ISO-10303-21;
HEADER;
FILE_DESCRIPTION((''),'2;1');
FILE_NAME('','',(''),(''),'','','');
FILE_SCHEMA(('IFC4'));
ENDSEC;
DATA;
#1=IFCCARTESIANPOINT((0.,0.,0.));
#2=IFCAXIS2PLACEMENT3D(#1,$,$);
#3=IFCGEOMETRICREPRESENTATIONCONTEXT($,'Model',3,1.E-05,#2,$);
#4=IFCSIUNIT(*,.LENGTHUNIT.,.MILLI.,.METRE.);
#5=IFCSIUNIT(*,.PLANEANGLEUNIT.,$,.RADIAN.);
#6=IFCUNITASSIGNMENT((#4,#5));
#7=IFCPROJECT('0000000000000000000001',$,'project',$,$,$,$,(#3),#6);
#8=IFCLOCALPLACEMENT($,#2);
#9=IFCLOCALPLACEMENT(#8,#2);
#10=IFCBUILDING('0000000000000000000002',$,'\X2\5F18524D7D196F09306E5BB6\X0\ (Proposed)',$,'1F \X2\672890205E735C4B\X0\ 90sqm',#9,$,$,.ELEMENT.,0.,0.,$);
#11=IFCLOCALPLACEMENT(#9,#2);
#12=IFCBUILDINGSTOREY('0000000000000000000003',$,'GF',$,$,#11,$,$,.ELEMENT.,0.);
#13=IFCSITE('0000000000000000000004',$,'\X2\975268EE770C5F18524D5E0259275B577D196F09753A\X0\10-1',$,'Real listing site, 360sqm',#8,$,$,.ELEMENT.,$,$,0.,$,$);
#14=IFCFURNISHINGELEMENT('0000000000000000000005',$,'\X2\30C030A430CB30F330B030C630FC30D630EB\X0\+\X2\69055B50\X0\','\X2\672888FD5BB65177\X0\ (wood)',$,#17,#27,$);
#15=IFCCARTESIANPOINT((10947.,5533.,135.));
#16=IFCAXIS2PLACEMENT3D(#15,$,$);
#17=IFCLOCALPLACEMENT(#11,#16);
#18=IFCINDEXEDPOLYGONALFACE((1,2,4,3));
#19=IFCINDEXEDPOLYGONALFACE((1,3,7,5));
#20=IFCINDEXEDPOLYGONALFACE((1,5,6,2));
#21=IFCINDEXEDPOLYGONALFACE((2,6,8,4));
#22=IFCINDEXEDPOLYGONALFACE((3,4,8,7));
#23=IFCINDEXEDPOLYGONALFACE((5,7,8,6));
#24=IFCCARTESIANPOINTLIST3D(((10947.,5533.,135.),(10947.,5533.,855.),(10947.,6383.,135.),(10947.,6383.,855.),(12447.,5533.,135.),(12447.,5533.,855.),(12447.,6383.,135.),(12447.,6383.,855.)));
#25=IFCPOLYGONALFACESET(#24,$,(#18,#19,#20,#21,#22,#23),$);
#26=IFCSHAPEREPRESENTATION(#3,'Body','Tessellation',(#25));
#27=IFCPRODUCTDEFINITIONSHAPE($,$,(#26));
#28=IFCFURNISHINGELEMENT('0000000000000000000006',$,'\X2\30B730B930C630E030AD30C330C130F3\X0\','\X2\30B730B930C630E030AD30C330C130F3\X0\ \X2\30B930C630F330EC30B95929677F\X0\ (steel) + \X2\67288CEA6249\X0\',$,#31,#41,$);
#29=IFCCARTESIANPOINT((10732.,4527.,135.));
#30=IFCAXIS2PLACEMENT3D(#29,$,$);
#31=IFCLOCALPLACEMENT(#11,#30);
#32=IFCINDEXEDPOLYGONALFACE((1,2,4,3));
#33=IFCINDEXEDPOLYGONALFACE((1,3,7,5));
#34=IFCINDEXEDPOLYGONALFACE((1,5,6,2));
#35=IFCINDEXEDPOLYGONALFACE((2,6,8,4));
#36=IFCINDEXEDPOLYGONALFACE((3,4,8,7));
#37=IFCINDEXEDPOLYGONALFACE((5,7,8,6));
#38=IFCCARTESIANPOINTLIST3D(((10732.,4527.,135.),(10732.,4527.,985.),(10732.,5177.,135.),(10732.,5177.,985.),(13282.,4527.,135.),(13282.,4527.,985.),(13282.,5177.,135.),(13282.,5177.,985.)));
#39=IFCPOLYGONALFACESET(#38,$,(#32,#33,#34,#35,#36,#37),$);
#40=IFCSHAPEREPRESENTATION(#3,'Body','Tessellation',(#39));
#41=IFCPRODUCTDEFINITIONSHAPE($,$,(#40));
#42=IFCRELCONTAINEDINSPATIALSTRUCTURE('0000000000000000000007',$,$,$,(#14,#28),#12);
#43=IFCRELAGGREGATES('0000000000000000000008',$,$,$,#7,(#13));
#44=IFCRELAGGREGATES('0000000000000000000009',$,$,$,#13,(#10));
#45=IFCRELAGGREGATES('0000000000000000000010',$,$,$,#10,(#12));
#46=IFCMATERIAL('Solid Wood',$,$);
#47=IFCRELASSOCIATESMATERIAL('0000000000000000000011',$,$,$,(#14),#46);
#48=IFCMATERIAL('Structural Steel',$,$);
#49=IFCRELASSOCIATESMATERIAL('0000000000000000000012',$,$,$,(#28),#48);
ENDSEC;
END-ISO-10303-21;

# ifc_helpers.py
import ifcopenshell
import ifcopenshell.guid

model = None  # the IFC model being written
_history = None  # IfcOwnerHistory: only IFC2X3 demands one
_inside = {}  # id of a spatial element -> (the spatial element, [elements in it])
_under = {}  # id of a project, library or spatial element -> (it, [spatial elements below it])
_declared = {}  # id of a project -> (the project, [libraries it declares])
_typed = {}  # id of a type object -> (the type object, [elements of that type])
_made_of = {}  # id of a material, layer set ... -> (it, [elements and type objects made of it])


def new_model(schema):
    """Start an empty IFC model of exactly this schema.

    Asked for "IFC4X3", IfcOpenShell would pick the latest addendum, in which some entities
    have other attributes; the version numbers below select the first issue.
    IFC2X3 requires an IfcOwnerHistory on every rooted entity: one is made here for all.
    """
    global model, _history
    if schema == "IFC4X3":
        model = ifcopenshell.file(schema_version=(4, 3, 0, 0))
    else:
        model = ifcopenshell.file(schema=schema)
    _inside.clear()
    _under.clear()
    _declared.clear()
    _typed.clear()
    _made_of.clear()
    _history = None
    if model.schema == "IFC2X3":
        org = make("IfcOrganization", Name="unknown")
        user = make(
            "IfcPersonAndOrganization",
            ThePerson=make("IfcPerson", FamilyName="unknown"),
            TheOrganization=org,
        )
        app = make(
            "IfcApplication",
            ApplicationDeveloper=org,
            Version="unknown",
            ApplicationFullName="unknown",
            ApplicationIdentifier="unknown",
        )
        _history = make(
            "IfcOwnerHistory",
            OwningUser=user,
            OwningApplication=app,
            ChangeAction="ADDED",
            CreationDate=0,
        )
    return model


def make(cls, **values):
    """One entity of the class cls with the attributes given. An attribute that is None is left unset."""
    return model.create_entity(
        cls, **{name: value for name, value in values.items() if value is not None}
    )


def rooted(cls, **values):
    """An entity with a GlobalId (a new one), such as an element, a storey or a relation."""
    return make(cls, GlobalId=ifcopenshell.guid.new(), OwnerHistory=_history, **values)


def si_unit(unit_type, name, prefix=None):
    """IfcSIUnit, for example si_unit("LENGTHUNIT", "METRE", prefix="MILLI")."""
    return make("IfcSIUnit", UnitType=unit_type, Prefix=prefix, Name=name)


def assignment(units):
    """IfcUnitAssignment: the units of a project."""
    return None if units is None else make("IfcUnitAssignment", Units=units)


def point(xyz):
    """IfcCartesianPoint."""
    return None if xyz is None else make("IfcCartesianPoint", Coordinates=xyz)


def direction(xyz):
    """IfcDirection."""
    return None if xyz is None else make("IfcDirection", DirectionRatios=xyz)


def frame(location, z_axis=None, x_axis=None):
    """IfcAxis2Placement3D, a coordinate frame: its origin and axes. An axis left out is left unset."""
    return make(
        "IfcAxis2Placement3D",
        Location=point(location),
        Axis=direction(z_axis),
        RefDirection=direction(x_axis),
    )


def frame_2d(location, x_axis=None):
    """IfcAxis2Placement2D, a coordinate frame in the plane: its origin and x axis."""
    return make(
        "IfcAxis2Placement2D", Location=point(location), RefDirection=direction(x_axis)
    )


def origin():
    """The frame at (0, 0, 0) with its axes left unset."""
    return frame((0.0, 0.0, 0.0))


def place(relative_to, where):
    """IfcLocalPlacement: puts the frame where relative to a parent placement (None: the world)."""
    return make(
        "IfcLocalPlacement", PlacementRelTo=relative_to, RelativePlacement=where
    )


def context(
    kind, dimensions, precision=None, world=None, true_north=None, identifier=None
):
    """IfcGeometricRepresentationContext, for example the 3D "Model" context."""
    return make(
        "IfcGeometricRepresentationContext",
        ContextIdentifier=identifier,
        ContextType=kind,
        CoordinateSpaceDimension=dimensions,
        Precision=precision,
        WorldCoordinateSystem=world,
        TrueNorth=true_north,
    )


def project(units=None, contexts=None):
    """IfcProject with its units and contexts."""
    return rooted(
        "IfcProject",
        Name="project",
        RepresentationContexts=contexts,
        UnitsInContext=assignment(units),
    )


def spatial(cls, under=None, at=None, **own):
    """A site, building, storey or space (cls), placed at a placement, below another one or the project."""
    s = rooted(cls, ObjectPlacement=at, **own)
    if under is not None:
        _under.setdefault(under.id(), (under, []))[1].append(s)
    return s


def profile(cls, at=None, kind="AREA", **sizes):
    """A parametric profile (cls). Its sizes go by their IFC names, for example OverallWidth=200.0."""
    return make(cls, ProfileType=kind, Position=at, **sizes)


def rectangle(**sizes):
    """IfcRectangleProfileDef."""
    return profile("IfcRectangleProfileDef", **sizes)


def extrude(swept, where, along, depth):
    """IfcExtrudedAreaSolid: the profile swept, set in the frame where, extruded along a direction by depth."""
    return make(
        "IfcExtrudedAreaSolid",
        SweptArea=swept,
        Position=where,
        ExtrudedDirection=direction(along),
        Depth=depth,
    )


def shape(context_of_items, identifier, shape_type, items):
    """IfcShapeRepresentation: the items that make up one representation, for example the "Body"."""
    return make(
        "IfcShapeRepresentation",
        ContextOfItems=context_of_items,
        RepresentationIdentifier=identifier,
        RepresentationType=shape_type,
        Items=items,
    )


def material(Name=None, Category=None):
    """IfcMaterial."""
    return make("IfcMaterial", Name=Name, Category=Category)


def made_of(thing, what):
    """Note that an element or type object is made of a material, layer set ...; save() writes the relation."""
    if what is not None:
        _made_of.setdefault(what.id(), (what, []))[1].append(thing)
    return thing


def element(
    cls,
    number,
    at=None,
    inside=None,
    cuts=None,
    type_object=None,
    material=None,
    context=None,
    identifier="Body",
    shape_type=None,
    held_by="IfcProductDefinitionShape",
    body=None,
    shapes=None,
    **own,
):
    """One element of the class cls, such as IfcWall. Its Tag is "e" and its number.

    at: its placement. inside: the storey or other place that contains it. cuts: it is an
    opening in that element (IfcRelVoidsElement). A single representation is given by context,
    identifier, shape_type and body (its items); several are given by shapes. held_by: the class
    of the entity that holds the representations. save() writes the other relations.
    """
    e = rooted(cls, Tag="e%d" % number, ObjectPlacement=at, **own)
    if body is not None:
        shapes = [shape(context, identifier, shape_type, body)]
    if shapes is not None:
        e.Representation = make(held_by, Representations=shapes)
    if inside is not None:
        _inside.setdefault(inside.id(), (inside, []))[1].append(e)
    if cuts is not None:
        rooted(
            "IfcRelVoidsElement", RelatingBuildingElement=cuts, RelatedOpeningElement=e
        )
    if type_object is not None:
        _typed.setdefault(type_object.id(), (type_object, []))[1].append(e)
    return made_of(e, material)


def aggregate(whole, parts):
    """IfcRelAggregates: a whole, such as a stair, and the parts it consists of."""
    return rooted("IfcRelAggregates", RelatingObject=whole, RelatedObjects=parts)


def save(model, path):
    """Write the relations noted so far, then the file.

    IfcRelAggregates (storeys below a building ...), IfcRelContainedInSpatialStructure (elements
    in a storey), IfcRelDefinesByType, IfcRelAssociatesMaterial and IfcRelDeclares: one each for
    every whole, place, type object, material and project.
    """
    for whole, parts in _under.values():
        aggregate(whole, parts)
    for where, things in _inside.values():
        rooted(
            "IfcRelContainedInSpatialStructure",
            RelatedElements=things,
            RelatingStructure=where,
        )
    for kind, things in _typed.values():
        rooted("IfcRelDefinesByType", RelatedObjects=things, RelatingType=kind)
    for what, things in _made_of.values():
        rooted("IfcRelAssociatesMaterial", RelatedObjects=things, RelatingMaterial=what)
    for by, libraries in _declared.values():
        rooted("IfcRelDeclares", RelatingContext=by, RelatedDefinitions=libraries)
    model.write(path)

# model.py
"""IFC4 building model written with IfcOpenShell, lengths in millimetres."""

from ifc_helpers import new_model, si_unit, frame, frame_2d, origin, place, context, project, spatial, rectangle, extrude, material, element, save


model = new_model("IFC4")

# Units and contexts
model_context = context("Model", 3, precision=1e-05, world=origin())
ifc_project = project(units=[si_unit("LENGTHUNIT", "METRE", prefix="MILLI"), si_unit("PLANEANGLEUNIT", "RADIAN")], contexts=[model_context])

# Site, building, storey
site_placement = place(None, origin())
site = spatial("IfcSite", under=ifc_project, at=site_placement, Name="青森県弘前市大字紙漉町10-1", ObjectType="Real listing site, 360sqm", CompositionType="ELEMENT", RefElevation=0.0)
building_placement = place(site_placement, origin())
building = spatial("IfcBuilding", under=site, at=building_placement, Name="弘前紙漉の家 (Proposed)", ObjectType="1F 木造平屋 90sqm", CompositionType="ELEMENT", ElevationOfRefHeight=0.0, ElevationOfTerrain=0.0)
storey_placement = place(building_placement, origin())
storey = spatial("IfcBuildingStorey", under=building, at=storey_placement, Name="GF", CompositionType="ELEMENT", Elevation=0.0)

# Shared definitions
ifc_material_1 = material(Name="Solid Wood")

# Shared definitions
ifc_material_2 = material(Name="Structural Steel")

# Furnishing elements
furnishing_1_placement = place(storey_placement, frame((10947.0, 5533.0, 135.0)))
element("IfcFurnishingElement", 1, at=furnishing_1_placement, inside=storey, material=ifc_material_1, Name="ダイニングテーブル+椅子", Description="木製家具 (wood)", context=model_context, shape_type="SweptSolid", body=[
    extrude(rectangle(XDim=1500.0, YDim=850.0, at=frame_2d((750.0, 425.0))), frame((10947.0, 5533.0, 135.0)), (0.0, 0.0, 1.0), 720.0),
])
furnishing_2_placement = place(storey_placement, frame((10732.0, 4527.0, 135.0)))
element("IfcFurnishingElement", 2, at=furnishing_2_placement, inside=storey, material=ifc_material_2, Name="システムキッチン", Description="システムキッチン ステンレス天板 (steel) + 木質扉", context=model_context, shape_type="SweptSolid", body=[
    extrude(rectangle(XDim=2550.0, YDim=650.0, at=frame_2d((1275.0, 325.0))), frame((10732.0, 4527.0, 135.0)), (0.0, 0.0, 1.0), 850.0),
])

save(model, "model.ifc")
